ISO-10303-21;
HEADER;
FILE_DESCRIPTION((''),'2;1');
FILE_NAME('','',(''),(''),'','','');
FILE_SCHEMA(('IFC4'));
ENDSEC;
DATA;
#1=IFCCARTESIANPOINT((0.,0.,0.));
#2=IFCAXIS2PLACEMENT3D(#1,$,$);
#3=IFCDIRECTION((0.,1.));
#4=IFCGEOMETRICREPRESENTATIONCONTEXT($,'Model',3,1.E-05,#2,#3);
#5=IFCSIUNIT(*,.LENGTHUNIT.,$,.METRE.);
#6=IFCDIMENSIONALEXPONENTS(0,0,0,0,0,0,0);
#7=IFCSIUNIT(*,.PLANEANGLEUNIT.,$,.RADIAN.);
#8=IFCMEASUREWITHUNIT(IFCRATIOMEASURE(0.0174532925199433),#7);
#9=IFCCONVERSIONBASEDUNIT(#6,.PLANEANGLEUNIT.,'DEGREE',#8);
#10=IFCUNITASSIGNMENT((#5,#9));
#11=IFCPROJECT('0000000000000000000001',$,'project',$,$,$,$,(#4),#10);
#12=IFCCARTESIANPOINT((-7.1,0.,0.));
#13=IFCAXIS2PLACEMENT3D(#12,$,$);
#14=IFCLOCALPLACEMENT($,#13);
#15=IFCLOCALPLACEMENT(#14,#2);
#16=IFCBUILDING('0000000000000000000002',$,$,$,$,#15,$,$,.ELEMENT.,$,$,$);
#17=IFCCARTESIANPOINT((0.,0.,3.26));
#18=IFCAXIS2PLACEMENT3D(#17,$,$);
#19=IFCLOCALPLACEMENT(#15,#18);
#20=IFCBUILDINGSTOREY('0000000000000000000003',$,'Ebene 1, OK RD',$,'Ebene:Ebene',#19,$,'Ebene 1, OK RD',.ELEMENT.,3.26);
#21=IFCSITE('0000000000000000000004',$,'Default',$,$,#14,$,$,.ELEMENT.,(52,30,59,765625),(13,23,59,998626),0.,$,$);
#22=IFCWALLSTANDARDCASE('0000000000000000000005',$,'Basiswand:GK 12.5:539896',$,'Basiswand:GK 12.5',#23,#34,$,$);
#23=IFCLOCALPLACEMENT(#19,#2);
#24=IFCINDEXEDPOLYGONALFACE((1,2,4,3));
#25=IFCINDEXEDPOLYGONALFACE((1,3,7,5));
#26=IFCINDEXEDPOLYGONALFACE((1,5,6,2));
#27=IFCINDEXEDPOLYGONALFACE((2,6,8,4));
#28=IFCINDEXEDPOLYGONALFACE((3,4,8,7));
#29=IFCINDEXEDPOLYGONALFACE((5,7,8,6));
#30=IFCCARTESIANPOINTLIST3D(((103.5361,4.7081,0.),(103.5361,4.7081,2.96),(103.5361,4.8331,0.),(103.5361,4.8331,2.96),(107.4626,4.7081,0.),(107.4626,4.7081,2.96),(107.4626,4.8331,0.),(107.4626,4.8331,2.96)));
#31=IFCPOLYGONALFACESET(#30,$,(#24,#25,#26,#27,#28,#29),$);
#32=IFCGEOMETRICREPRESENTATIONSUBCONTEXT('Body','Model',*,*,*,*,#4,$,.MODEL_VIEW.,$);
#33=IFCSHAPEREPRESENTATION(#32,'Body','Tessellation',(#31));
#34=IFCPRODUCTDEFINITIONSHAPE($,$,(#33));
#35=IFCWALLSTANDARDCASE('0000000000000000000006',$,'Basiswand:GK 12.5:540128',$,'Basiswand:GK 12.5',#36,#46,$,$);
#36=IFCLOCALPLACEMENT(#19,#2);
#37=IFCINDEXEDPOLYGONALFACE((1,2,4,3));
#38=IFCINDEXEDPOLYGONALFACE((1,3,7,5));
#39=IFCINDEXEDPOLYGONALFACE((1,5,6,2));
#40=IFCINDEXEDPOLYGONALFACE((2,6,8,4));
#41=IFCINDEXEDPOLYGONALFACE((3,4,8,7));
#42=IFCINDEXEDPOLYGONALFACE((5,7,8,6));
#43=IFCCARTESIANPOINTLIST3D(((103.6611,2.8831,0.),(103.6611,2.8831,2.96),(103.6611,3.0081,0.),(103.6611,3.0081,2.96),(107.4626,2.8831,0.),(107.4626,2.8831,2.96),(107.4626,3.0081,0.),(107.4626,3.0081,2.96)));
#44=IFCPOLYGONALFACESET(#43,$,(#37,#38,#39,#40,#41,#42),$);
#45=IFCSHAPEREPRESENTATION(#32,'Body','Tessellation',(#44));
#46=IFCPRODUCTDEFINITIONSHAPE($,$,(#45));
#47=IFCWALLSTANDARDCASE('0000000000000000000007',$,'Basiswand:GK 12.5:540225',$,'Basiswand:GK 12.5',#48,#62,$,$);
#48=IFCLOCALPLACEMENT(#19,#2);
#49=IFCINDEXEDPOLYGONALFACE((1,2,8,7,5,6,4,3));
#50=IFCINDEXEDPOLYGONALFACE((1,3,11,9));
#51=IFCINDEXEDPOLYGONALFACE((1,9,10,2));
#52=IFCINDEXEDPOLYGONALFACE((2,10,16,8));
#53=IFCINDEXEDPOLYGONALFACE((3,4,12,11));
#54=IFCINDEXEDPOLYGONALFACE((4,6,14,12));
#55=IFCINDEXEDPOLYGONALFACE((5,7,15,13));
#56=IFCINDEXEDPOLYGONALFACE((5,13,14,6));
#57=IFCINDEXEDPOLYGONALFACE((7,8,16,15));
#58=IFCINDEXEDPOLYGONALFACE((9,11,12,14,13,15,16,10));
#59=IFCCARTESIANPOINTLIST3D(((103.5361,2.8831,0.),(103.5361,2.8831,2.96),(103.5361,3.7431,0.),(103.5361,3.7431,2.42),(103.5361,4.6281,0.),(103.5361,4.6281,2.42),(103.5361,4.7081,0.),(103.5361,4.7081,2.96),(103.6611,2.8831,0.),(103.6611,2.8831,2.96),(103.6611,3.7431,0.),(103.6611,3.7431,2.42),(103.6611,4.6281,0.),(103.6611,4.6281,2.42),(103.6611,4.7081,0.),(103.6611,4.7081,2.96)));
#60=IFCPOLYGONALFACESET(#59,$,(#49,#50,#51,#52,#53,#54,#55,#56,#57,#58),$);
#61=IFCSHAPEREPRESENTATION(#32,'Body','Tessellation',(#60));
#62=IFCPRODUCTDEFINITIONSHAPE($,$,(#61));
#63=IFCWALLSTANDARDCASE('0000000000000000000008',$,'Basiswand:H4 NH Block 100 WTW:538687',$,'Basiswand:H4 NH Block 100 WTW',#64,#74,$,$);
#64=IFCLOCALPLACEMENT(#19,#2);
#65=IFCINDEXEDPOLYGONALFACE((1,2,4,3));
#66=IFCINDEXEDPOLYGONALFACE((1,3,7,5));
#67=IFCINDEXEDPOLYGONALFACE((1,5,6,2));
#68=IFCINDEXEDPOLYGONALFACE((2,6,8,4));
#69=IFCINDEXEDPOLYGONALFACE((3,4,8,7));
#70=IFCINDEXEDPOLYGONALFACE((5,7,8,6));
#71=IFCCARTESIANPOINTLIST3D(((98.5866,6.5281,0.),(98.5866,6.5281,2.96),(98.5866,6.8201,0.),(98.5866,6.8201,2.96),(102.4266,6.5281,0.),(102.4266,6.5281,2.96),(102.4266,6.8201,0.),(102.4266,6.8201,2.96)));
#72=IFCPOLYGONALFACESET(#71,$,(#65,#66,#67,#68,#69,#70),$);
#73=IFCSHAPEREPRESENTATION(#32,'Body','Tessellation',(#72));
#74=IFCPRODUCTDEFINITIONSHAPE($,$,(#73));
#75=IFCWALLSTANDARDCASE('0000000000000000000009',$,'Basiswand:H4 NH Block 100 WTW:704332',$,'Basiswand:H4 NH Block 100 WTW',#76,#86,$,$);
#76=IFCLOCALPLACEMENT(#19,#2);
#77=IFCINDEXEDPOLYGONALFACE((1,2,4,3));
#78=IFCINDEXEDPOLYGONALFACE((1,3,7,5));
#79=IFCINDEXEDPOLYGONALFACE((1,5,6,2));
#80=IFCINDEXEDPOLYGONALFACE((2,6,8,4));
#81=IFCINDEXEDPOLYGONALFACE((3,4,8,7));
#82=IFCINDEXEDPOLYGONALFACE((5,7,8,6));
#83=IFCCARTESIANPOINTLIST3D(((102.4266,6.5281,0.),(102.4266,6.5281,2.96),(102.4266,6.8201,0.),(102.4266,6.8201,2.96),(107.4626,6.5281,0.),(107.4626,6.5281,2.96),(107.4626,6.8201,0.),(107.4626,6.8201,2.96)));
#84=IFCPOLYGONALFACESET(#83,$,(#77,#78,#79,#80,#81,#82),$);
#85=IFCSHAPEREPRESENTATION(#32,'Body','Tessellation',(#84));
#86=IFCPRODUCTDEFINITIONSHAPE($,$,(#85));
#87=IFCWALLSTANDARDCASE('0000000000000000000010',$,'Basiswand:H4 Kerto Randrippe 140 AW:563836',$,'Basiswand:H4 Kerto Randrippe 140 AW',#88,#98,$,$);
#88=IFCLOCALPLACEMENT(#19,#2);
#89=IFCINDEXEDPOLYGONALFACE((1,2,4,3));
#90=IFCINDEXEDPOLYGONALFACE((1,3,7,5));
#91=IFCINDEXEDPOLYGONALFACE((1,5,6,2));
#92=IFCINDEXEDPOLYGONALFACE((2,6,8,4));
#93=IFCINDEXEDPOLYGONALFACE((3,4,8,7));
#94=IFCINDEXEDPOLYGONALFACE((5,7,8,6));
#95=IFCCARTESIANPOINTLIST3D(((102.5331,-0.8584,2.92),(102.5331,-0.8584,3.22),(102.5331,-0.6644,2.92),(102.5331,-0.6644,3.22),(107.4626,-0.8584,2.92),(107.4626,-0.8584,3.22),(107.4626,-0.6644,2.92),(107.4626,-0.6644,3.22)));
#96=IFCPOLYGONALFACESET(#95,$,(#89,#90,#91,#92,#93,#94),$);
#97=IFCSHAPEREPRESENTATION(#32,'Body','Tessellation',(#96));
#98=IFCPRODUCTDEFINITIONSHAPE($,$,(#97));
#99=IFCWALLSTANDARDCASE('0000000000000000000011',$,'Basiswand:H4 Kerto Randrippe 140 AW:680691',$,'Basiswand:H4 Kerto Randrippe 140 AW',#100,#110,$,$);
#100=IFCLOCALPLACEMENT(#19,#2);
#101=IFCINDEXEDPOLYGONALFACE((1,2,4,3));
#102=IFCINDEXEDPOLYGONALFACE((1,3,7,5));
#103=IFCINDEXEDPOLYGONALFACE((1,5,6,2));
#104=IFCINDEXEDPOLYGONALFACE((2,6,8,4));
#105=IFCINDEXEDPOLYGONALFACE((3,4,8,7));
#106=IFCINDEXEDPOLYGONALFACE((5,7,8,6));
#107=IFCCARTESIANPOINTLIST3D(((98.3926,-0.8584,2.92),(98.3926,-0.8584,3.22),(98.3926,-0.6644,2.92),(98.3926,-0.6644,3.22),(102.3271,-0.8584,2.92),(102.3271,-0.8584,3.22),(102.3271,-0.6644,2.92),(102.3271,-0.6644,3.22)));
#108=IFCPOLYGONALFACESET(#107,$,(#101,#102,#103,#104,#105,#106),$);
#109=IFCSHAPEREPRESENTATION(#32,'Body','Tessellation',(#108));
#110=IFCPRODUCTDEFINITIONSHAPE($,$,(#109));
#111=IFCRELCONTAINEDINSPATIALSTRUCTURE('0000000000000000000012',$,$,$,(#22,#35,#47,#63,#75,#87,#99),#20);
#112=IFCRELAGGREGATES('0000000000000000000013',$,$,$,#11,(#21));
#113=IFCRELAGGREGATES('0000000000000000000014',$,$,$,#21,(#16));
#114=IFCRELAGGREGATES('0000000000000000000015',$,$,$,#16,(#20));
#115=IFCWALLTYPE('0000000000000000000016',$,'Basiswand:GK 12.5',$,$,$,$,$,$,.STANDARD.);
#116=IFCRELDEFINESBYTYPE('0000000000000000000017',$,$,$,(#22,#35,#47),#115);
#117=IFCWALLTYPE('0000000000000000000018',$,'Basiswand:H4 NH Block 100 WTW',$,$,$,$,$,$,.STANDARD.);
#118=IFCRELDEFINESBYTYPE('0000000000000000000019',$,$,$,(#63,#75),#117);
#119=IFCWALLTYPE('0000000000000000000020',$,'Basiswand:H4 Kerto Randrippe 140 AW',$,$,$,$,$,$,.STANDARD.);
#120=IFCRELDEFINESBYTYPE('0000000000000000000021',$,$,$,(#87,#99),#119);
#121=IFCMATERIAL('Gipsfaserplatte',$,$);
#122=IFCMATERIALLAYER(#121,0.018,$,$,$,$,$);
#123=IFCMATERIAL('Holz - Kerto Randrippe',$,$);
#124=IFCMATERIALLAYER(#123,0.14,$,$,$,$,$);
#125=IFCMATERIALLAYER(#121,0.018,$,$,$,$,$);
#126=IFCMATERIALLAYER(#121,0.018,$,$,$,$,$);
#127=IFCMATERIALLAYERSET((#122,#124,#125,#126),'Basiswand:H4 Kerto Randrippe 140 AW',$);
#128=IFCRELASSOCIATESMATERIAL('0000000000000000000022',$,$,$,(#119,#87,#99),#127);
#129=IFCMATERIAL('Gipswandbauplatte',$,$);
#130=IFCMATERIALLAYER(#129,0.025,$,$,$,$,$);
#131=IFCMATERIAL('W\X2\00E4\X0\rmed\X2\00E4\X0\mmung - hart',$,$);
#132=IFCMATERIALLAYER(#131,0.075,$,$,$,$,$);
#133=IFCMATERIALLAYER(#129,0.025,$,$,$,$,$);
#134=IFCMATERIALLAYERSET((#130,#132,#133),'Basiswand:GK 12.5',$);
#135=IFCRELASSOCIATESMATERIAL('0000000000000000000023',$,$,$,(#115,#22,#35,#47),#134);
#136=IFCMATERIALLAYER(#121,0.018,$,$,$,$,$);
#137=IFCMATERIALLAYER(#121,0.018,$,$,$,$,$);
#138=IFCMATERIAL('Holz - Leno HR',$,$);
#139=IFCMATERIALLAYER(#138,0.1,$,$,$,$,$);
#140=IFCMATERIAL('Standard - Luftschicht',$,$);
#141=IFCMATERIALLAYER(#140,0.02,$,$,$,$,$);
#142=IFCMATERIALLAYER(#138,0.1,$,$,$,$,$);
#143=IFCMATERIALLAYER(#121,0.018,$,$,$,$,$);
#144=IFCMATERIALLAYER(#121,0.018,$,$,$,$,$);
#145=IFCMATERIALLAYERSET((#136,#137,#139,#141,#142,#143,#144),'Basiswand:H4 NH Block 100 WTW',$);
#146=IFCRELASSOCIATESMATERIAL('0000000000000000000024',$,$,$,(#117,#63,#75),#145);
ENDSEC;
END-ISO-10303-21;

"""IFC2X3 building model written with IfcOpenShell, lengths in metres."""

from ifc_helpers import new_model, entity, si_unit, converted_unit, direction, frame, frame_2d, origin, place, context, subcontext, project, spatial, rectangle, extrude, material, layer, layer_set, layer_usage, type_object, element, save


model = new_model("IFC2X3")

# Units and contexts
model_context = context("Model", 3, precision=1e-05, world=origin(), true_north=direction((0.0, 1.0)))
body_context = subcontext(model_context, "Body", "Model", "MODEL_VIEW")
ifc_project = project(units=[si_unit("LENGTHUNIT", "METRE"), converted_unit("PLANEANGLEUNIT", "DEGREE", entity("IfcRatioMeasure", 0.0174532925199433), si_unit("PLANEANGLEUNIT", "RADIAN"), dimensions=[0, 0, 0, 0, 0, 0, 0])], contexts=[model_context])

# Site, building, storey
site_placement = place(None, frame((-7.1, 0.0, 0.0)))
site = spatial("IfcSite", under=ifc_project, at=site_placement, Name="Default", CompositionType="ELEMENT", RefLatitude=(52, 30, 59, 765625), RefLongitude=(13, 23, 59, 998626), RefElevation=0.0)
building_placement = place(site_placement, origin())
building = spatial("IfcBuilding", under=site, at=building_placement, CompositionType="ELEMENT")
storey_placement = place(building_placement, frame((0.0, 0.0, 3.26)))
storey = spatial("IfcBuildingStorey", under=building, at=storey_placement, Name="Ebene 1, OK RD", ObjectType="Ebene:Ebene", LongName="Ebene 1, OK RD", CompositionType="ELEMENT", Elevation=3.26)

# Shared definitions
ifc_material_1 = material(Name="Gipsfaserplatte")
ifc_layer_1 = layer(ifc_material_1, 0.018)
ifc_material_2 = material(Name="Holz - Kerto Randrippe")
ifc_layer_2 = layer(ifc_material_2, 0.14)
ifc_layer_3 = layer(ifc_material_1, 0.018)
ifc_layer_4 = layer(ifc_material_1, 0.018)
ifc_layer_set_1 = layer_set([ifc_layer_1, ifc_layer_2, ifc_layer_3, ifc_layer_4], Name="Basiswand:H4 Kerto Randrippe 140 AW")
wall_type_1 = type_object("IfcWallType", Name="Basiswand:H4 Kerto Randrippe 140 AW", PredefinedType="STANDARD", material=ifc_layer_set_1)

# Shared definitions
ifc_material_3 = material(Name="Holz - Leno HR")

# Walls
ifc_material_4 = material(Name="Gipswandbauplatte")
ifc_layer_5 = layer(ifc_material_4, 0.025)
ifc_material_5 = material(Name="Wärmedämmung - hart")
ifc_layer_6 = layer(ifc_material_5, 0.075)
ifc_layer_7 = layer(ifc_material_4, 0.025)
ifc_layer_set_2 = layer_set([ifc_layer_5, ifc_layer_6, ifc_layer_7], Name="Basiswand:GK 12.5")
wall_type_2 = type_object("IfcWallType", Name="Basiswand:GK 12.5", PredefinedType="STANDARD", material=ifc_layer_set_2)
ifc_layer_usage_1 = layer_usage(ifc_layer_set_2, "AXIS2", "NEGATIVE", 0.0625)
wall_1_placement = place(storey_placement, frame((103.5361, 4.7706, 0.0)))
element("IfcWallStandardCase", 1, at=wall_1_placement, inside=storey, type_object=wall_type_2, material=ifc_layer_usage_1, Name="Basiswand:GK 12.5:539896", ObjectType="Basiswand:GK 12.5", context=body_context, shape_type="SweptSolid", body=[
    extrude(rectangle(XDim=3.9265, YDim=0.125, at=frame_2d((1.9633, 0.0), x_axis=(-1.0, 0.0))), origin(), (0.0, 0.0, 1.0), 2.96),
])
ifc_layer_usage_2 = layer_usage(ifc_layer_set_2, "AXIS2", "NEGATIVE", 0.0625)
wall_2_placement = place(storey_placement, frame((103.6611, 2.9456, 0.0)))
element("IfcWallStandardCase", 2, at=wall_2_placement, inside=storey, type_object=wall_type_2, material=ifc_layer_usage_2, Name="Basiswand:GK 12.5:540128", ObjectType="Basiswand:GK 12.5", context=body_context, shape_type="SweptSolid", body=[
    extrude(rectangle(XDim=3.8015, YDim=0.125, at=frame_2d((1.9008, 0.0), x_axis=(-1.0, 0.0))), origin(), (0.0, 0.0, 1.0), 2.96),
])

# Wall, opening
ifc_layer_usage_3 = layer_usage(ifc_layer_set_2, "AXIS2", "NEGATIVE", 0.0625)
wall_3_placement = place(storey_placement, frame((103.5986, 4.7081, 0.0), z_axis=(0.0, 0.0, 1.0), x_axis=(0.0, -1.0, 0.0)))
wall_3 = element("IfcWallStandardCase", 3, at=wall_3_placement, inside=storey, type_object=wall_type_2, material=ifc_layer_usage_3, Name="Basiswand:GK 12.5:540225", ObjectType="Basiswand:GK 12.5", context=body_context, shape_type="SweptSolid", body=[
    extrude(rectangle(XDim=1.825, YDim=0.125, at=frame_2d((0.9125, 0.0), x_axis=(-1.0, 0.0))), origin(), (0.0, 0.0, 1.0), 2.96),
])
opening_1_placement = place(wall_3_placement, frame((0.08, -0.0625, 0.0)))
element("IfcOpeningElement", 4, at=opening_1_placement, cuts=wall_3, ObjectType="Opening", context=body_context, shape_type="SweptSolid", body=[
    extrude(rectangle(XDim=2.42, YDim=0.885, at=frame_2d((1.21, 0.4425), x_axis=(1.0, 0.0))), frame((0.0, 0.0, 0.0), z_axis=(0.0, 1.0, 0.0), x_axis=(0.0, 0.0, 1.0)), (0.0, 0.0, 1.0), 0.125),
])

# Walls
ifc_layer_8 = layer(ifc_material_1, 0.018)
ifc_layer_9 = layer(ifc_material_1, 0.018)
ifc_layer_10 = layer(ifc_material_3, 0.1)
ifc_material_6 = material(Name="Standard - Luftschicht")
ifc_layer_11 = layer(ifc_material_6, 0.02)
ifc_layer_12 = layer(ifc_material_3, 0.1)
ifc_layer_13 = layer(ifc_material_1, 0.018)
ifc_layer_14 = layer(ifc_material_1, 0.018)
ifc_layer_set_3 = layer_set([ifc_layer_8, ifc_layer_9, ifc_layer_10, ifc_layer_11, ifc_layer_12, ifc_layer_13, ifc_layer_14], Name="Basiswand:H4 NH Block 100 WTW")
ifc_layer_usage_4 = layer_usage(ifc_layer_set_3, "AXIS2", "NEGATIVE", 0.146)
wall_type_3 = type_object("IfcWallType", Name="Basiswand:H4 NH Block 100 WTW", PredefinedType="STANDARD", material=ifc_layer_set_3)
wall_4_placement = place(storey_placement, frame((98.5866, 6.6741, 0.0)))
element("IfcWallStandardCase", 5, at=wall_4_placement, inside=storey, type_object=wall_type_3, material=ifc_layer_usage_4, Name="Basiswand:H4 NH Block 100 WTW:538687", ObjectType="Basiswand:H4 NH Block 100 WTW", context=body_context, shape_type="SweptSolid", body=[
    extrude(rectangle(XDim=3.84, YDim=0.292, at=frame_2d((1.92, 0.0), x_axis=(-1.0, 0.0))), origin(), (0.0, 0.0, 1.0), 2.96),
])
ifc_layer_usage_5 = layer_usage(ifc_layer_set_3, "AXIS2", "NEGATIVE", 0.146)
wall_5_placement = place(storey_placement, frame((102.4266, 6.6741, 0.0)))
element("IfcWallStandardCase", 6, at=wall_5_placement, inside=storey, type_object=wall_type_3, material=ifc_layer_usage_5, Name="Basiswand:H4 NH Block 100 WTW:704332", ObjectType="Basiswand:H4 NH Block 100 WTW", context=body_context, shape_type="SweptSolid", body=[
    extrude(rectangle(XDim=5.036, YDim=0.292, at=frame_2d((2.518, 0.0), x_axis=(-1.0, 0.0))), origin(), (0.0, 0.0, 1.0), 2.96),
])
ifc_layer_usage_6 = layer_usage(ifc_layer_set_1, "AXIS2", "NEGATIVE", 0.097)
wall_6_placement = place(storey_placement, frame((107.4626, -0.7614, 2.92), z_axis=(0.0, 0.0, 1.0), x_axis=(-1.0, 0.0, 0.0)))
element("IfcWallStandardCase", 7, at=wall_6_placement, inside=storey, type_object=wall_type_1, material=ifc_layer_usage_6, Name="Basiswand:H4 Kerto Randrippe 140 AW:563836", ObjectType="Basiswand:H4 Kerto Randrippe 140 AW", context=body_context, shape_type="SweptSolid", body=[
    extrude(rectangle(XDim=4.9295, YDim=0.194, at=frame_2d((2.4648, 0.0), x_axis=(-1.0, 0.0))), origin(), (0.0, 0.0, 1.0), 0.3),
])
ifc_layer_usage_7 = layer_usage(ifc_layer_set_1, "AXIS2", "NEGATIVE", 0.097)
wall_7_placement = place(storey_placement, frame((102.3271, -0.7614, 2.92), z_axis=(0.0, 0.0, 1.0), x_axis=(-1.0, 0.0, 0.0)))
element("IfcWallStandardCase", 8, at=wall_7_placement, inside=storey, type_object=wall_type_1, material=ifc_layer_usage_7, Name="Basiswand:H4 Kerto Randrippe 140 AW:680691", ObjectType="Basiswand:H4 Kerto Randrippe 140 AW", context=body_context, shape_type="SweptSolid", body=[
    extrude(rectangle(XDim=3.9345, YDim=0.194, at=frame_2d((1.9672, 0.0), x_axis=(-1.0, 0.0))), origin(), (0.0, 0.0, 1.0), 0.3),
])

save(model, "model.ifc")
